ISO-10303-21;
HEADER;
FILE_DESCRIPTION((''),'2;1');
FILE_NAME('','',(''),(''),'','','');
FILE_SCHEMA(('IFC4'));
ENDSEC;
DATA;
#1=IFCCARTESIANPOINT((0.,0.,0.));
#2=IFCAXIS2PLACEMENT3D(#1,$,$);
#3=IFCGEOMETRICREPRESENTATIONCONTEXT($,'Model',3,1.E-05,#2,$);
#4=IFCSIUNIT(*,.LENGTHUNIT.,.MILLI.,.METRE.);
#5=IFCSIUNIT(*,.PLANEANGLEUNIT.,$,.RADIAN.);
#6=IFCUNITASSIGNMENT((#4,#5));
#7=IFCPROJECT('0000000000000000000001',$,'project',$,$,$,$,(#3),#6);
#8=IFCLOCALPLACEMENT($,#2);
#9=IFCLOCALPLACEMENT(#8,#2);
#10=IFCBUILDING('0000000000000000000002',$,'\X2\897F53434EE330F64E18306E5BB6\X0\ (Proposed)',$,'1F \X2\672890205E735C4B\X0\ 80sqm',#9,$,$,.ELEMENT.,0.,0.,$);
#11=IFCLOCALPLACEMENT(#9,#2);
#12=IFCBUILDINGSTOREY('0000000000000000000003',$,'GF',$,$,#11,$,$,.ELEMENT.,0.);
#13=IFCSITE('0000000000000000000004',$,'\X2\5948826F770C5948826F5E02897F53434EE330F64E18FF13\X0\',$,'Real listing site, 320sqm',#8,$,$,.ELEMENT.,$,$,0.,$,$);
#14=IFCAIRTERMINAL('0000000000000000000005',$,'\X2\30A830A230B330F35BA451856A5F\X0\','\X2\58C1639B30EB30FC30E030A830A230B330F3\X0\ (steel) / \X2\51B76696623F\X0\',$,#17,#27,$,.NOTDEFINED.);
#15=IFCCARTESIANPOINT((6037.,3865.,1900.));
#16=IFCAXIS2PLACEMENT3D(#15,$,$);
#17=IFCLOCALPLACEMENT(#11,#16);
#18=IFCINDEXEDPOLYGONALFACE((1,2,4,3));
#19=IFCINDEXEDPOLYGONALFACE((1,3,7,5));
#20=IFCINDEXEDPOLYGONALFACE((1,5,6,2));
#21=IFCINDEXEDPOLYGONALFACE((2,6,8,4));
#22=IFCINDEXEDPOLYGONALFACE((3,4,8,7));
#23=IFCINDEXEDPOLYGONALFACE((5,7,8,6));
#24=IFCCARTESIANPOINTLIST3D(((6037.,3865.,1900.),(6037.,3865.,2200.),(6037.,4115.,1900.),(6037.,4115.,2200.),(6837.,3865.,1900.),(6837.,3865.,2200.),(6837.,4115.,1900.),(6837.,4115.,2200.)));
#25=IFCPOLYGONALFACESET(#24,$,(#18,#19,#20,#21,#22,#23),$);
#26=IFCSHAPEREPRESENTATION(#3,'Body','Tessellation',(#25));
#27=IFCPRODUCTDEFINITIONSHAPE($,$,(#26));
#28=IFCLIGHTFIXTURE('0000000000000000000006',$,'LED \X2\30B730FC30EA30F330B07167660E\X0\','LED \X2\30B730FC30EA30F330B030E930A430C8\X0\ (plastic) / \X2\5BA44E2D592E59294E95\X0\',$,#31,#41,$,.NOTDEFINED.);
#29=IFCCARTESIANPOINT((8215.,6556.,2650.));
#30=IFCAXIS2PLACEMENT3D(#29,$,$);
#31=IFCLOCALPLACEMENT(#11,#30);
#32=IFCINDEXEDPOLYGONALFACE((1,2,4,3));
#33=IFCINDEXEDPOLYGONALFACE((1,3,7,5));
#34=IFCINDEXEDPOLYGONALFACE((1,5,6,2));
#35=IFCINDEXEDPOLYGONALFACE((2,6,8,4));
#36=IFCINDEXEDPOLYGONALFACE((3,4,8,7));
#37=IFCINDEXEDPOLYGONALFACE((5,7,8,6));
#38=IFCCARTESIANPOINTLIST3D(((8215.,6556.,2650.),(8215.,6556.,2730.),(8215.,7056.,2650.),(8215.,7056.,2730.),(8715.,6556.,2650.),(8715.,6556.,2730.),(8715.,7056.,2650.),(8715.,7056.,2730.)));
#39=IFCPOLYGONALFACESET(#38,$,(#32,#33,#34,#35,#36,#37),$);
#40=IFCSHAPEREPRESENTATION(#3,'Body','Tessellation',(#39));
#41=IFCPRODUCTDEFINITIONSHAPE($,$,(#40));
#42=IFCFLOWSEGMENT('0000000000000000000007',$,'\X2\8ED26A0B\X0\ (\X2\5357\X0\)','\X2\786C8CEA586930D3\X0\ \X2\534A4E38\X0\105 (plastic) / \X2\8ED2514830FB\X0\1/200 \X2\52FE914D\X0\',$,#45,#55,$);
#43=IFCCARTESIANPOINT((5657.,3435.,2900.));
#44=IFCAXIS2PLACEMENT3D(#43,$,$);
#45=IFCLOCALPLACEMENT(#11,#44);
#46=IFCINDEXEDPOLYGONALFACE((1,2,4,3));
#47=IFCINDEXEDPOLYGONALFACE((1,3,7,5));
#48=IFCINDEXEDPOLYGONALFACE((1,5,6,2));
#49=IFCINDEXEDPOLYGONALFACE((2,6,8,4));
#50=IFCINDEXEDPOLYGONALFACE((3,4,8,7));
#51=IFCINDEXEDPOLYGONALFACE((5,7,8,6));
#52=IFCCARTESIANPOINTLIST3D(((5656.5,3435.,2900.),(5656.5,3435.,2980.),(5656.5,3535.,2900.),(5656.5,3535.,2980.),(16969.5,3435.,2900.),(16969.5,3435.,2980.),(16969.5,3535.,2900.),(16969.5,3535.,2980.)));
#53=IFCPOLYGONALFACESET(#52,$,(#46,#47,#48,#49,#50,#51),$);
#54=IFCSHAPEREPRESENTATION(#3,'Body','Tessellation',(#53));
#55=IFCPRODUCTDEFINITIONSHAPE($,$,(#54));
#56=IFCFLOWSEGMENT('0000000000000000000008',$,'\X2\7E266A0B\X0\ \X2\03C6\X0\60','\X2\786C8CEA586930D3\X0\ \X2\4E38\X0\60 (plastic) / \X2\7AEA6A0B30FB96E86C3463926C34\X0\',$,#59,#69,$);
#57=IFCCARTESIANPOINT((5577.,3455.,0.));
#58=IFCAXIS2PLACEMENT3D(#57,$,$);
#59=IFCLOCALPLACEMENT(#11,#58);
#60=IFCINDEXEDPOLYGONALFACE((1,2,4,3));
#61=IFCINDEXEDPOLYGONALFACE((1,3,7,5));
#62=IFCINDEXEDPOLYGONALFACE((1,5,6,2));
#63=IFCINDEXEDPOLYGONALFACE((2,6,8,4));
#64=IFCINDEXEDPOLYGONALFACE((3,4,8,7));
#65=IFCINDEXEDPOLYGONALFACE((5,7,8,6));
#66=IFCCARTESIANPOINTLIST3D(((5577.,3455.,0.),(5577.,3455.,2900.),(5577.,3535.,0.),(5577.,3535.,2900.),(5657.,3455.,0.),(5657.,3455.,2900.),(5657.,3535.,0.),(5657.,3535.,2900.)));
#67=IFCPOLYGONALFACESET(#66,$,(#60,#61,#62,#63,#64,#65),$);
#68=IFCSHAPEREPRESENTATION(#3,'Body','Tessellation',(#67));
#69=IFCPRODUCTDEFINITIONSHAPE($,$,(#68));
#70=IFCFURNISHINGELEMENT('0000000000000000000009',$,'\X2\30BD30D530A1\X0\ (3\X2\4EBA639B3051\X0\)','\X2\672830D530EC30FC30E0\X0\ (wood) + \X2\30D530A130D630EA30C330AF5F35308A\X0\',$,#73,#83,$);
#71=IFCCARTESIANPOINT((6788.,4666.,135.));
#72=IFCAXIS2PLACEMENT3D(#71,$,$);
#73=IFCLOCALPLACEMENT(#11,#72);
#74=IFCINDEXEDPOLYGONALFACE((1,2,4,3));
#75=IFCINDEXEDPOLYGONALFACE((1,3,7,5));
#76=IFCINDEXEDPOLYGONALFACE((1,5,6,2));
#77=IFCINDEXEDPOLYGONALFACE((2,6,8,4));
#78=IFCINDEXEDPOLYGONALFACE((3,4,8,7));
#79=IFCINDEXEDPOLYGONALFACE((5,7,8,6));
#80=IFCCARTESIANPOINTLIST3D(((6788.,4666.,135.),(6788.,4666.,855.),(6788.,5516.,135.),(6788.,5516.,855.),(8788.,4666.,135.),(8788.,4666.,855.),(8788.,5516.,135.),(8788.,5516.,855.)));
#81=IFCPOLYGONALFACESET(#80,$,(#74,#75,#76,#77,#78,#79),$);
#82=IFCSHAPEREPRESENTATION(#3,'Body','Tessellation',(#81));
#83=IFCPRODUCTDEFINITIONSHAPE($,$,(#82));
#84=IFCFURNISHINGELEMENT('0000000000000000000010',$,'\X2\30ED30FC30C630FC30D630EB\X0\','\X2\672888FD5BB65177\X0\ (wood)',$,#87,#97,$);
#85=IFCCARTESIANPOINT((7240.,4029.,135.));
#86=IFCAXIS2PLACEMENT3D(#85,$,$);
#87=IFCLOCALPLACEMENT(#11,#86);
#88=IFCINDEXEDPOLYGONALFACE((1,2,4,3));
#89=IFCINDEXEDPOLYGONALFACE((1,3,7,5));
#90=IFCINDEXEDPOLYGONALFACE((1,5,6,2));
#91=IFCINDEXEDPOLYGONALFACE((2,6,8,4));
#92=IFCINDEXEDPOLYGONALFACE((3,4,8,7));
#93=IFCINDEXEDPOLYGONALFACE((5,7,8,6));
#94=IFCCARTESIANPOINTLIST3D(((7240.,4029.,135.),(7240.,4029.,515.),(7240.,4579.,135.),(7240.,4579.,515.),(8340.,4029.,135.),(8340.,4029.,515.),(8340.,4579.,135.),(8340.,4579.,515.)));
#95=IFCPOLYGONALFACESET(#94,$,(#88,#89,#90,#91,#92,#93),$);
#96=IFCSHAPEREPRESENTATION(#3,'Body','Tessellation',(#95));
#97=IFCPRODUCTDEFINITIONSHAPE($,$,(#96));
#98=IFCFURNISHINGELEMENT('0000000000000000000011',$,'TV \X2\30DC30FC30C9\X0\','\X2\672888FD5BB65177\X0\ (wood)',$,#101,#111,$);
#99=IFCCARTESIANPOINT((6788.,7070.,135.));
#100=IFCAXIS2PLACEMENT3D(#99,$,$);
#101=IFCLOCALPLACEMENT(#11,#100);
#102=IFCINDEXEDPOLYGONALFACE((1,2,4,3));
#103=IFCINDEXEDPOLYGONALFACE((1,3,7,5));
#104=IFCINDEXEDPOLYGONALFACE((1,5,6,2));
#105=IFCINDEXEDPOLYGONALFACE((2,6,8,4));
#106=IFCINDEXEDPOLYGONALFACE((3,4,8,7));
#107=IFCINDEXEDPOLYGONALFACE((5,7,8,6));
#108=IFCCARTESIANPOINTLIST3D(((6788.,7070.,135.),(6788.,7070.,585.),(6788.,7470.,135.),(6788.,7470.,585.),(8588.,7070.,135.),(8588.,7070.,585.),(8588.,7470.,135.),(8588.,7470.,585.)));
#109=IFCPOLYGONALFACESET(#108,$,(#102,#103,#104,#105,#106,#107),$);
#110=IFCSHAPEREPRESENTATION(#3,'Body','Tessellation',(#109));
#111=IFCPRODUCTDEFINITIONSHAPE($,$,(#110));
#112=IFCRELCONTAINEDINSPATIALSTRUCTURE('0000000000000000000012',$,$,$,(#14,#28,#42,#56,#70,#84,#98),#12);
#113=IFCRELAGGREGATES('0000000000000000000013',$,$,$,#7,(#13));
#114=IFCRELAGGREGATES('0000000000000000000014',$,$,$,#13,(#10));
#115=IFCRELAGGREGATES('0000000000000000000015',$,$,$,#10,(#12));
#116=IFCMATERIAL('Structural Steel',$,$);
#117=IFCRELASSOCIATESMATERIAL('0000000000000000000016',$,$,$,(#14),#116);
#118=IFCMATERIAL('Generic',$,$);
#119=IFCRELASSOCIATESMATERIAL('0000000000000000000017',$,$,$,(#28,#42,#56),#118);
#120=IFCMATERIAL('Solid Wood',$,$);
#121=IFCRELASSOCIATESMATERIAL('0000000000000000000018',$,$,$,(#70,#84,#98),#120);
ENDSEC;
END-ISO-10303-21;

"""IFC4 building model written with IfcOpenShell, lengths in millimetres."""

from ifc_helpers import new_model, si_unit, frame, frame_2d, origin, place, context, project, spatial, rectangle, extrude, material, element, save


model = new_model("IFC4")

# Units and contexts
model_context = context("Model", 3, precision=1e-05, world=origin())
ifc_project = project(units=[si_unit("LENGTHUNIT", "METRE", prefix="MILLI"), si_unit("PLANEANGLEUNIT", "RADIAN")], contexts=[model_context])

# Site, building, storey
site_placement = place(None, origin())
site = spatial("IfcSite", under=ifc_project, at=site_placement, Name="奈良県奈良市西千代ヶ丘３", ObjectType="Real listing site, 320sqm", CompositionType="ELEMENT", RefElevation=0.0)
building_placement = place(site_placement, origin())
building = spatial("IfcBuilding", under=site, at=building_placement, Name="西千代ヶ丘の家 (Proposed)", ObjectType="1F 木造平屋 80sqm", CompositionType="ELEMENT", ElevationOfRefHeight=0.0, ElevationOfTerrain=0.0)
storey_placement = place(building_placement, origin())
storey = spatial("IfcBuildingStorey", under=building, at=storey_placement, Name="GF", CompositionType="ELEMENT", Elevation=0.0)

# Shared definitions
ifc_material_1 = material(Name="Solid Wood")

# Shared definitions
ifc_material_2 = material(Name="Structural Steel")

# Shared definitions
ifc_material_3 = material(Name="Generic")

# Air terminal
air_terminal_placement = place(storey_placement, frame((6037.0, 3865.0, 1900.0)))
element("IfcAirTerminal", 1, at=air_terminal_placement, inside=storey, material=ifc_material_2, Name="エアコン室内機", Description="壁掛ルームエアコン (steel) / 冷暖房", PredefinedType="NOTDEFINED", context=model_context, shape_type="SweptSolid", body=[
    extrude(rectangle(XDim=800.0, YDim=250.0, at=frame_2d((400.0, 125.0))), frame((6037.0, 3865.0, 1900.0)), (0.0, 0.0, 1.0), 300.0),
])

# Light fixture
light_fixture_placement = place(storey_placement, frame((8215.0, 6556.0, 2650.0)))
element("IfcLightFixture", 2, at=light_fixture_placement, inside=storey, material=ifc_material_3, Name="LED シーリング照明", Description="LED シーリングライト (plastic) / 室中央天井", PredefinedType="NOTDEFINED", context=model_context, shape_type="SweptSolid", body=[
    extrude(rectangle(XDim=500.0, YDim=500.0, at=frame_2d((250.0, 250.0))), frame((8215.0, 6556.0, 2650.0)), (0.0, 0.0, 1.0), 80.0),
])

# Flow segments
flow_segment_1_placement = place(storey_placement, frame((5657.0, 3435.0, 2900.0)))
element("IfcFlowSegment", 3, at=flow_segment_1_placement, inside=storey, material=ifc_material_3, Name="軒樋 (南)", Description="硬質塩ビ 半丸105 (plastic) / 軒先・1/200 勾配", context=model_context, shape_type="SweptSolid", body=[
    extrude(rectangle(XDim=11313.0, YDim=100.0, at=frame_2d((5656.0, 50.0))), frame((5657.0, 3435.0, 2900.0)), (0.0, 0.0, 1.0), 80.0),
])
flow_segment_2_placement = place(storey_placement, frame((5577.0, 3455.0, 0.0)))
element("IfcFlowSegment", 4, at=flow_segment_2_placement, inside=storey, material=ifc_material_3, Name="縦樋 φ60", Description="硬質塩ビ 丸60 (plastic) / 竪樋・雨水排水", context=model_context, shape_type="SweptSolid", body=[
    extrude(rectangle(XDim=80.0, YDim=80.0, at=frame_2d((40.0, 40.0))), frame((5577.0, 3455.0, 0.0)), (0.0, 0.0, 1.0), 2900.0),
])

# Furnishing elements
furnishing_1_placement = place(storey_placement, frame((6788.0, 4666.0, 135.0)))
element("IfcFurnishingElement", 5, at=furnishing_1_placement, inside=storey, material=ifc_material_1, Name="ソファ (3人掛け)", Description="木フレーム (wood) + ファブリック張り", context=model_context, shape_type="SweptSolid", body=[
    extrude(rectangle(XDim=2000.0, YDim=850.0, at=frame_2d((1000.0, 425.0))), frame((6788.0, 4666.0, 135.0)), (0.0, 0.0, 1.0), 720.0),
])
furnishing_2_placement = place(storey_placement, frame((7240.0, 4029.0, 135.0)))
element("IfcFurnishingElement", 6, at=furnishing_2_placement, inside=storey, material=ifc_material_1, Name="ローテーブル", Description="木製家具 (wood)", context=model_context, shape_type="SweptSolid", body=[
    extrude(rectangle(XDim=1100.0, YDim=550.0, at=frame_2d((550.0, 275.0))), frame((7240.0, 4029.0, 135.0)), (0.0, 0.0, 1.0), 380.0),
])
furnishing_3_placement = place(storey_placement, frame((6788.0, 7070.0, 135.0)))
element("IfcFurnishingElement", 7, at=furnishing_3_placement, inside=storey, material=ifc_material_1, Name="TV ボード", Description="木製家具 (wood)", context=model_context, shape_type="SweptSolid", body=[
    extrude(rectangle(XDim=1800.0, YDim=400.0, at=frame_2d((900.0, 200.0))), frame((6788.0, 7070.0, 135.0)), (0.0, 0.0, 1.0), 450.0),
])

save(model, "model.ifc")
